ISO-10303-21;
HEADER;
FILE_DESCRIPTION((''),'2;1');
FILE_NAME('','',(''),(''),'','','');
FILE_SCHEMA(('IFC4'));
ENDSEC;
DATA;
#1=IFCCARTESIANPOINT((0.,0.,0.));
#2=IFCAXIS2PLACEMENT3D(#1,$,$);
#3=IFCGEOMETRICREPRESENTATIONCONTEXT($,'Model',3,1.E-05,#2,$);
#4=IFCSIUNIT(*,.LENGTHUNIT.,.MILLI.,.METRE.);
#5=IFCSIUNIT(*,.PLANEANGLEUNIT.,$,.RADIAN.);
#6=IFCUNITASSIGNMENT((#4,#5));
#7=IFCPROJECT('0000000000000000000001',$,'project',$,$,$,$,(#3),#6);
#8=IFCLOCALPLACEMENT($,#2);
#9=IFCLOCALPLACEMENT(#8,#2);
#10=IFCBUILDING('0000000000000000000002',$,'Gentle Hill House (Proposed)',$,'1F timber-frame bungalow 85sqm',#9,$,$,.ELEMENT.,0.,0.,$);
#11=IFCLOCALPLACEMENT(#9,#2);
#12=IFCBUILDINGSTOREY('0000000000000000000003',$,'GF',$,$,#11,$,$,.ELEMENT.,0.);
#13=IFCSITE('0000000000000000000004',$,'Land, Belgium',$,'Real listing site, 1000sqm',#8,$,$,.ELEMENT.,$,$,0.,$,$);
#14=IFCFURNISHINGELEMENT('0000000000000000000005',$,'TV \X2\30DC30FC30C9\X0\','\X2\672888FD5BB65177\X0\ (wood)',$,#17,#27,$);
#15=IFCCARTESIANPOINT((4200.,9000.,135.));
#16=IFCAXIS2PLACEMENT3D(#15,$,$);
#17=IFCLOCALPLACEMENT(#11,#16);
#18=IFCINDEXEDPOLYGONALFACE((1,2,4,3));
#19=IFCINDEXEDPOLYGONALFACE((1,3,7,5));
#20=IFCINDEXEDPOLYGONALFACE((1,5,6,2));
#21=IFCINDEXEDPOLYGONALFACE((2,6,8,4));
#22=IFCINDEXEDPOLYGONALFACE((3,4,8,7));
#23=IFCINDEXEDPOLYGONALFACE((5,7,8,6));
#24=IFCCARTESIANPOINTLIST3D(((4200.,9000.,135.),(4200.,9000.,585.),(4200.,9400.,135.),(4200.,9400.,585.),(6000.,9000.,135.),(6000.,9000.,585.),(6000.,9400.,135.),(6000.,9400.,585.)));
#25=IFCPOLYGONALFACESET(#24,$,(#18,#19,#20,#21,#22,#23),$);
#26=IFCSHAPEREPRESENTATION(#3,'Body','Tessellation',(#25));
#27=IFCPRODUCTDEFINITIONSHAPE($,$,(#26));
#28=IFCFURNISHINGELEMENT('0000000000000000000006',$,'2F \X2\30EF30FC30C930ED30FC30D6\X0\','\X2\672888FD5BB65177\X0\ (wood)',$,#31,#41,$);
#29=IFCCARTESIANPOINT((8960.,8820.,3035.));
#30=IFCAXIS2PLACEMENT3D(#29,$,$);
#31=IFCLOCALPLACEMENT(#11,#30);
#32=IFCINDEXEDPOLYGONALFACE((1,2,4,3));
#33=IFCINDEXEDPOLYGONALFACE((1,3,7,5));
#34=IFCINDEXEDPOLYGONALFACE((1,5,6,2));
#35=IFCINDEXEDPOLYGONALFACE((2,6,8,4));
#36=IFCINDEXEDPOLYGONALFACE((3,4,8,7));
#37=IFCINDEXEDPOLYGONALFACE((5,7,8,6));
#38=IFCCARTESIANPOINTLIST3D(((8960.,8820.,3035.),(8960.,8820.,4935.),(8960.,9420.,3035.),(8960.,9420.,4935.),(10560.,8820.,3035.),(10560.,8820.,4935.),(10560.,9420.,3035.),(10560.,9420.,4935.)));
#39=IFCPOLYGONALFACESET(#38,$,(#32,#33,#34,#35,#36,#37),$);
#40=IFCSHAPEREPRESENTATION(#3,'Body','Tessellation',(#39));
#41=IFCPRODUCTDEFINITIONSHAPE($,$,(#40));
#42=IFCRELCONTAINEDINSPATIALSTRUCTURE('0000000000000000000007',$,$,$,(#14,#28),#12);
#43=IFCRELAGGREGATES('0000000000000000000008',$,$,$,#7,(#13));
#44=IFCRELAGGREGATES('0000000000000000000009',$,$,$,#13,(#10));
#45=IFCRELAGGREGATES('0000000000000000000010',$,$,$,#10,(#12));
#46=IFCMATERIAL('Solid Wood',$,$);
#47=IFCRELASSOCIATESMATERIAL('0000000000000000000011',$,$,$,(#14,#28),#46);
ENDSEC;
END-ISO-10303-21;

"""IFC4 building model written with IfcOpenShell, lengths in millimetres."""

from ifc_helpers import new_model, si_unit, frame, frame_2d, origin, place, context, project, spatial, rectangle, extrude, material, element, save


model = new_model("IFC4")

# Units and contexts
model_context = context("Model", 3, precision=1e-05, world=origin())
ifc_project = project(units=[si_unit("LENGTHUNIT", "METRE", prefix="MILLI"), si_unit("PLANEANGLEUNIT", "RADIAN")], contexts=[model_context])

# Site, building, storey
site_placement = place(None, origin())
site = spatial("IfcSite", under=ifc_project, at=site_placement, Name="Land, Belgium", ObjectType="Real listing site, 1000sqm", CompositionType="ELEMENT", RefElevation=0.0)
building_placement = place(site_placement, origin())
building = spatial("IfcBuilding", under=site, at=building_placement, Name="Gentle Hill House (Proposed)", ObjectType="1F timber-frame bungalow 85sqm", CompositionType="ELEMENT", ElevationOfRefHeight=0.0, ElevationOfTerrain=0.0)
storey_placement = place(building_placement, origin())
storey = spatial("IfcBuildingStorey", under=building, at=storey_placement, Name="GF", CompositionType="ELEMENT", Elevation=0.0)

# Shared definitions
ifc_material_1 = material(Name="Solid Wood")

# Furnishing elements
furnishing_1_placement = place(storey_placement, frame((4200.0, 9000.0, 135.0)))
element("IfcFurnishingElement", 1, at=furnishing_1_placement, inside=storey, material=ifc_material_1, Name="TV ボード", Description="木製家具 (wood)", context=model_context, shape_type="SweptSolid", body=[
    extrude(rectangle(XDim=1800.0, YDim=400.0, at=frame_2d((900.0, 200.0))), frame((4200.0, 9000.0, 135.0)), (0.0, 0.0, 1.0), 450.0),
])
furnishing_2_placement = place(storey_placement, frame((8960.0, 8820.0, 3035.0)))
element("IfcFurnishingElement", 2, at=furnishing_2_placement, inside=storey, material=ifc_material_1, Name="2F ワードローブ", Description="木製家具 (wood)", context=model_context, shape_type="SweptSolid", body=[
    extrude(rectangle(XDim=1600.0, YDim=600.0, at=frame_2d((800.0, 300.0))), frame((8960.0, 8820.0, 3035.0)), (0.0, 0.0, 1.0), 1900.0),
])

save(model, "model.ifc")
